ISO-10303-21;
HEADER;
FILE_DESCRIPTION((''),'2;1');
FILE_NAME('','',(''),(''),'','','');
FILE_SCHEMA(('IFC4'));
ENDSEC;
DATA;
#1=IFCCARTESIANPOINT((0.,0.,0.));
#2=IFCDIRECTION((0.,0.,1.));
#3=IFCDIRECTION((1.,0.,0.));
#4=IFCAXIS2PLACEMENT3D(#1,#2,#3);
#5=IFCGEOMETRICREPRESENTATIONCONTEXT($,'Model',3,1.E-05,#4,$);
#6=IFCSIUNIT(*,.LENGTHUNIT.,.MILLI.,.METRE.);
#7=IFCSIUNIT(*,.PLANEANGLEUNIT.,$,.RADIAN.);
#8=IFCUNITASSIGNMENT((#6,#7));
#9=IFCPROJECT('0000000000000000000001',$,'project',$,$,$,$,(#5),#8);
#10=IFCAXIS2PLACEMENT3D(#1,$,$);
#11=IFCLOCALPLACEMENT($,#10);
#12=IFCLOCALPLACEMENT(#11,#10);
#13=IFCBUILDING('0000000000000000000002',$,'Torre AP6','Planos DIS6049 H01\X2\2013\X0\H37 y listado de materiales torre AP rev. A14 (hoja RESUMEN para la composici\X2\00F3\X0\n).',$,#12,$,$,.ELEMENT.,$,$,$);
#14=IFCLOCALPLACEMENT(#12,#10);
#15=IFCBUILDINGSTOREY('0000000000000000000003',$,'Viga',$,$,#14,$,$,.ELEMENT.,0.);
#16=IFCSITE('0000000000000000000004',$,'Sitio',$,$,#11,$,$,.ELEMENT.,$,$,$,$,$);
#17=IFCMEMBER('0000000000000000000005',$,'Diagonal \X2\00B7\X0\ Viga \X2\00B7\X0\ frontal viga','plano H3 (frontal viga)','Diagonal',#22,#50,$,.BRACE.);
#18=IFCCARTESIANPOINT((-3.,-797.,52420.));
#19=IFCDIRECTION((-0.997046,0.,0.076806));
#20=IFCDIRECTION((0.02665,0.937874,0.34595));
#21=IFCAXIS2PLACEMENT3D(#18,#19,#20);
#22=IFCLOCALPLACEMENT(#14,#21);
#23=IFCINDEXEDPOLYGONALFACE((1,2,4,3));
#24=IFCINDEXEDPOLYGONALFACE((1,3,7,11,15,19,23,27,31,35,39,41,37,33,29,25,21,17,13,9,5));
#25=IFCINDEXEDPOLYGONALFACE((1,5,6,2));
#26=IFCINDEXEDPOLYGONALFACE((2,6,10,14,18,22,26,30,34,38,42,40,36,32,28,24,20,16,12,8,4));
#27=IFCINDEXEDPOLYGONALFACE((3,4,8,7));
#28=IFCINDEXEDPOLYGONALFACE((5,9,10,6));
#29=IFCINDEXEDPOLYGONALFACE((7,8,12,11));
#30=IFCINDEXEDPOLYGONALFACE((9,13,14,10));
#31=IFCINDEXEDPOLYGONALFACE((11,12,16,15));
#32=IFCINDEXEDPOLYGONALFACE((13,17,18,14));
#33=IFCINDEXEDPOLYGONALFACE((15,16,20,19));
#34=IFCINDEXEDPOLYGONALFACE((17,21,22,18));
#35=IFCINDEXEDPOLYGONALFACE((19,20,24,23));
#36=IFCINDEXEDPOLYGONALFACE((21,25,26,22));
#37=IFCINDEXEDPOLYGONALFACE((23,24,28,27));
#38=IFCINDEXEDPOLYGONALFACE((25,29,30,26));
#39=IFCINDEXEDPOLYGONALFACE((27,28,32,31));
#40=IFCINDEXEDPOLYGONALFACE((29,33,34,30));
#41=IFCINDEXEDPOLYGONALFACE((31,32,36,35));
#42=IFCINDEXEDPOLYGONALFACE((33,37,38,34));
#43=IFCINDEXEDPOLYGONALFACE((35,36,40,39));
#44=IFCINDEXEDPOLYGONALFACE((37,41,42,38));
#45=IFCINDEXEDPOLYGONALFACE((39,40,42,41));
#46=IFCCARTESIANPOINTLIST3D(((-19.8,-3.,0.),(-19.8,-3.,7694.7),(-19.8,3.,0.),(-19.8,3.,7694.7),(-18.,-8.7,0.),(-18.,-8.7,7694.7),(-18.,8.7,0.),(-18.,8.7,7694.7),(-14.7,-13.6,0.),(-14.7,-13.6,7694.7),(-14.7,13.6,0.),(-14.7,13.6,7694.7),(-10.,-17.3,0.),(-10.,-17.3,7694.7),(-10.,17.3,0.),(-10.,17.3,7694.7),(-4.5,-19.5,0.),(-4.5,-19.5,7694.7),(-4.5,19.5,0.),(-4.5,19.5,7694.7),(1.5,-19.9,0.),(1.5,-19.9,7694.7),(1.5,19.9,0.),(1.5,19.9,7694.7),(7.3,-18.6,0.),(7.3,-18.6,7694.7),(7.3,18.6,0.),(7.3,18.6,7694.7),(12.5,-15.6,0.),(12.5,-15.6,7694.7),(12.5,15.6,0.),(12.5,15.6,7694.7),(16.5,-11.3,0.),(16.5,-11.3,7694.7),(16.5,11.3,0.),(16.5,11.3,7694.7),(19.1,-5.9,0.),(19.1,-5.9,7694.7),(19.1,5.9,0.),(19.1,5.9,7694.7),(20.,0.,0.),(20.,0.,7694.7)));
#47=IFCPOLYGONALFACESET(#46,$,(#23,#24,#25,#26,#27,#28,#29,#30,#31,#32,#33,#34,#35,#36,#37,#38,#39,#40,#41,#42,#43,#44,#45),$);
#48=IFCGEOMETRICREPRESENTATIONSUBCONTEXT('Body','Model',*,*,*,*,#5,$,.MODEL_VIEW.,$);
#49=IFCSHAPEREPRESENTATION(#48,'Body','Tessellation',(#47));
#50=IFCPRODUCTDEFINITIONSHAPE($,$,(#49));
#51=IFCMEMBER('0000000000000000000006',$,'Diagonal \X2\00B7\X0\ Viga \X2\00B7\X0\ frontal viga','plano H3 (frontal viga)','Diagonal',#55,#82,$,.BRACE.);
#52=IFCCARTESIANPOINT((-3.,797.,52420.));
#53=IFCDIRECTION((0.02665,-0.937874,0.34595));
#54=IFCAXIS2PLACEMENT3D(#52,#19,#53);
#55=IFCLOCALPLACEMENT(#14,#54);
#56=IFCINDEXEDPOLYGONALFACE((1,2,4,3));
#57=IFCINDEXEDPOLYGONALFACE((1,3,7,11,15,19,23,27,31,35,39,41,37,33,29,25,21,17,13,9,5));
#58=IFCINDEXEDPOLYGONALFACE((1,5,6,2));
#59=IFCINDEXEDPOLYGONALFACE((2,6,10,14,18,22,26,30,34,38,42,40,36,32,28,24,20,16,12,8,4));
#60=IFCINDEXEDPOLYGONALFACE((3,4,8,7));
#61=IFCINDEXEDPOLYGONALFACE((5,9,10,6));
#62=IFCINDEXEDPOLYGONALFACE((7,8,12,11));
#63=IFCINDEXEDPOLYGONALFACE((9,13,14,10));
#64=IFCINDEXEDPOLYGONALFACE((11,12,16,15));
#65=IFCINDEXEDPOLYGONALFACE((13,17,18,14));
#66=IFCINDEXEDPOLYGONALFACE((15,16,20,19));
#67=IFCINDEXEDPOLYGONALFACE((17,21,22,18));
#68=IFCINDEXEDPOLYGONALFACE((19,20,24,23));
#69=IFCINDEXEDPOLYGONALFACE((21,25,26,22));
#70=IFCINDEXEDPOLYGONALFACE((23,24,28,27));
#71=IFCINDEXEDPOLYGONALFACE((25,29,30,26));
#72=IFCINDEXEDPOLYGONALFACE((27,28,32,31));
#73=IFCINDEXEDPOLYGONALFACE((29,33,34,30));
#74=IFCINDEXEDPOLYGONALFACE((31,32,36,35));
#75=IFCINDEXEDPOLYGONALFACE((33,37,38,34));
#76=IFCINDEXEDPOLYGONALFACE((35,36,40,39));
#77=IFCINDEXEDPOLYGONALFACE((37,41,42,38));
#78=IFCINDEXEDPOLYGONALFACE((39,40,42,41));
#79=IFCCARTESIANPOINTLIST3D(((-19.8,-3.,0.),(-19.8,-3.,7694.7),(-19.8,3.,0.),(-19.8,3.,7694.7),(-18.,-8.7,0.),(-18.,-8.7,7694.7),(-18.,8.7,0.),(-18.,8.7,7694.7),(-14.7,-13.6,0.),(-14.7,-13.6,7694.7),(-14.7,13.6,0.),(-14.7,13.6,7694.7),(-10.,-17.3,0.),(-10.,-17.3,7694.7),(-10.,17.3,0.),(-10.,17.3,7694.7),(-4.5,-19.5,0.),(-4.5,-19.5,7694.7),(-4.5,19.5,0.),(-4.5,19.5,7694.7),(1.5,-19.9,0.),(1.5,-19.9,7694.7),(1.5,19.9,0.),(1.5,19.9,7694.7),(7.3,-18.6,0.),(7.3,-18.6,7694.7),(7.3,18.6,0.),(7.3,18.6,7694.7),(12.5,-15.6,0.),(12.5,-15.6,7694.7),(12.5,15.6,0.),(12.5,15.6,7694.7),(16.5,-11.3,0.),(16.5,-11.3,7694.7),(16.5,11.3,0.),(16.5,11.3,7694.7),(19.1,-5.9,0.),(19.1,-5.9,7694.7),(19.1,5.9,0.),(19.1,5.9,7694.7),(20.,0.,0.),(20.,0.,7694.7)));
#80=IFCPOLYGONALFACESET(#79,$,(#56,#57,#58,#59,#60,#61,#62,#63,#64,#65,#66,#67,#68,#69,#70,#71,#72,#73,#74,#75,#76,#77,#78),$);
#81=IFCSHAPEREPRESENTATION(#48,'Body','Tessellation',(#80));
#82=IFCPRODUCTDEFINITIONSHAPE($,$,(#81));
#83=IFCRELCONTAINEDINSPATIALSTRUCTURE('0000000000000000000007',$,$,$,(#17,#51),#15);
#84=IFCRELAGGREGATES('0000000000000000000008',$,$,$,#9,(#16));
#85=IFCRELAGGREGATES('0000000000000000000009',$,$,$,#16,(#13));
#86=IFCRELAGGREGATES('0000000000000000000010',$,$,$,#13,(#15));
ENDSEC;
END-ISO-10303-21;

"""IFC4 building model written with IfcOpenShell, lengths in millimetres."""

from ifc_helpers import new_model, si_unit, frame, origin, origin_with_axes, place, context, subcontext, project, spatial, circle, extrude, element, save


model = new_model("IFC4")

# Units and contexts
model_context = context("Model", 3, precision=1e-05, world=origin_with_axes())
body_context = subcontext(model_context, "Body", "Model", "MODEL_VIEW")
ifc_project = project(units=[si_unit("LENGTHUNIT", "METRE", prefix="MILLI"), si_unit("PLANEANGLEUNIT", "RADIAN")], contexts=[model_context])

# Site, building, storey
site_placement = place(None, origin())
site = spatial("IfcSite", under=ifc_project, at=site_placement, Name="Sitio", CompositionType="ELEMENT")
building_placement = place(site_placement, origin())
building = spatial("IfcBuilding", under=site, at=building_placement, Name="Torre AP6", Description="Planos DIS6049 H01–H37 y listado de materiales torre AP rev. A14 (hoja RESUMEN para la composición).", CompositionType="ELEMENT")
storey_placement = place(building_placement, origin())
storey = spatial("IfcBuildingStorey", under=building, at=storey_placement, Name="Viga", CompositionType="ELEMENT", Elevation=0.0)

# Members
for number, where, z_axis, x_axis, name in (
    (1, (-3.0, -797.0, 52420.0), (-0.997046, 0.0, 0.076806), (0.02665, 0.937874, 0.34595), "Diagonal · Viga · frontal viga"),
    (2, (-3.0, 797.0, 52420.0), (-0.997046, 0.0, 0.076806), (0.02665, -0.937874, 0.34595), "Diagonal · Viga · frontal viga"),
):
    element("IfcMember", number, at=place(storey_placement, frame(where, z_axis=z_axis, x_axis=x_axis)), inside=storey, Name=name, Description="plano H3 (frontal viga)", ObjectType="Diagonal", PredefinedType="BRACE", context=body_context, shape_type="SweptSolid", body=[
        extrude(circle(Radius=20.0), None, (0.0, 0.0, 1.0), 7694.7),
    ])

save(model, "model.ifc")
